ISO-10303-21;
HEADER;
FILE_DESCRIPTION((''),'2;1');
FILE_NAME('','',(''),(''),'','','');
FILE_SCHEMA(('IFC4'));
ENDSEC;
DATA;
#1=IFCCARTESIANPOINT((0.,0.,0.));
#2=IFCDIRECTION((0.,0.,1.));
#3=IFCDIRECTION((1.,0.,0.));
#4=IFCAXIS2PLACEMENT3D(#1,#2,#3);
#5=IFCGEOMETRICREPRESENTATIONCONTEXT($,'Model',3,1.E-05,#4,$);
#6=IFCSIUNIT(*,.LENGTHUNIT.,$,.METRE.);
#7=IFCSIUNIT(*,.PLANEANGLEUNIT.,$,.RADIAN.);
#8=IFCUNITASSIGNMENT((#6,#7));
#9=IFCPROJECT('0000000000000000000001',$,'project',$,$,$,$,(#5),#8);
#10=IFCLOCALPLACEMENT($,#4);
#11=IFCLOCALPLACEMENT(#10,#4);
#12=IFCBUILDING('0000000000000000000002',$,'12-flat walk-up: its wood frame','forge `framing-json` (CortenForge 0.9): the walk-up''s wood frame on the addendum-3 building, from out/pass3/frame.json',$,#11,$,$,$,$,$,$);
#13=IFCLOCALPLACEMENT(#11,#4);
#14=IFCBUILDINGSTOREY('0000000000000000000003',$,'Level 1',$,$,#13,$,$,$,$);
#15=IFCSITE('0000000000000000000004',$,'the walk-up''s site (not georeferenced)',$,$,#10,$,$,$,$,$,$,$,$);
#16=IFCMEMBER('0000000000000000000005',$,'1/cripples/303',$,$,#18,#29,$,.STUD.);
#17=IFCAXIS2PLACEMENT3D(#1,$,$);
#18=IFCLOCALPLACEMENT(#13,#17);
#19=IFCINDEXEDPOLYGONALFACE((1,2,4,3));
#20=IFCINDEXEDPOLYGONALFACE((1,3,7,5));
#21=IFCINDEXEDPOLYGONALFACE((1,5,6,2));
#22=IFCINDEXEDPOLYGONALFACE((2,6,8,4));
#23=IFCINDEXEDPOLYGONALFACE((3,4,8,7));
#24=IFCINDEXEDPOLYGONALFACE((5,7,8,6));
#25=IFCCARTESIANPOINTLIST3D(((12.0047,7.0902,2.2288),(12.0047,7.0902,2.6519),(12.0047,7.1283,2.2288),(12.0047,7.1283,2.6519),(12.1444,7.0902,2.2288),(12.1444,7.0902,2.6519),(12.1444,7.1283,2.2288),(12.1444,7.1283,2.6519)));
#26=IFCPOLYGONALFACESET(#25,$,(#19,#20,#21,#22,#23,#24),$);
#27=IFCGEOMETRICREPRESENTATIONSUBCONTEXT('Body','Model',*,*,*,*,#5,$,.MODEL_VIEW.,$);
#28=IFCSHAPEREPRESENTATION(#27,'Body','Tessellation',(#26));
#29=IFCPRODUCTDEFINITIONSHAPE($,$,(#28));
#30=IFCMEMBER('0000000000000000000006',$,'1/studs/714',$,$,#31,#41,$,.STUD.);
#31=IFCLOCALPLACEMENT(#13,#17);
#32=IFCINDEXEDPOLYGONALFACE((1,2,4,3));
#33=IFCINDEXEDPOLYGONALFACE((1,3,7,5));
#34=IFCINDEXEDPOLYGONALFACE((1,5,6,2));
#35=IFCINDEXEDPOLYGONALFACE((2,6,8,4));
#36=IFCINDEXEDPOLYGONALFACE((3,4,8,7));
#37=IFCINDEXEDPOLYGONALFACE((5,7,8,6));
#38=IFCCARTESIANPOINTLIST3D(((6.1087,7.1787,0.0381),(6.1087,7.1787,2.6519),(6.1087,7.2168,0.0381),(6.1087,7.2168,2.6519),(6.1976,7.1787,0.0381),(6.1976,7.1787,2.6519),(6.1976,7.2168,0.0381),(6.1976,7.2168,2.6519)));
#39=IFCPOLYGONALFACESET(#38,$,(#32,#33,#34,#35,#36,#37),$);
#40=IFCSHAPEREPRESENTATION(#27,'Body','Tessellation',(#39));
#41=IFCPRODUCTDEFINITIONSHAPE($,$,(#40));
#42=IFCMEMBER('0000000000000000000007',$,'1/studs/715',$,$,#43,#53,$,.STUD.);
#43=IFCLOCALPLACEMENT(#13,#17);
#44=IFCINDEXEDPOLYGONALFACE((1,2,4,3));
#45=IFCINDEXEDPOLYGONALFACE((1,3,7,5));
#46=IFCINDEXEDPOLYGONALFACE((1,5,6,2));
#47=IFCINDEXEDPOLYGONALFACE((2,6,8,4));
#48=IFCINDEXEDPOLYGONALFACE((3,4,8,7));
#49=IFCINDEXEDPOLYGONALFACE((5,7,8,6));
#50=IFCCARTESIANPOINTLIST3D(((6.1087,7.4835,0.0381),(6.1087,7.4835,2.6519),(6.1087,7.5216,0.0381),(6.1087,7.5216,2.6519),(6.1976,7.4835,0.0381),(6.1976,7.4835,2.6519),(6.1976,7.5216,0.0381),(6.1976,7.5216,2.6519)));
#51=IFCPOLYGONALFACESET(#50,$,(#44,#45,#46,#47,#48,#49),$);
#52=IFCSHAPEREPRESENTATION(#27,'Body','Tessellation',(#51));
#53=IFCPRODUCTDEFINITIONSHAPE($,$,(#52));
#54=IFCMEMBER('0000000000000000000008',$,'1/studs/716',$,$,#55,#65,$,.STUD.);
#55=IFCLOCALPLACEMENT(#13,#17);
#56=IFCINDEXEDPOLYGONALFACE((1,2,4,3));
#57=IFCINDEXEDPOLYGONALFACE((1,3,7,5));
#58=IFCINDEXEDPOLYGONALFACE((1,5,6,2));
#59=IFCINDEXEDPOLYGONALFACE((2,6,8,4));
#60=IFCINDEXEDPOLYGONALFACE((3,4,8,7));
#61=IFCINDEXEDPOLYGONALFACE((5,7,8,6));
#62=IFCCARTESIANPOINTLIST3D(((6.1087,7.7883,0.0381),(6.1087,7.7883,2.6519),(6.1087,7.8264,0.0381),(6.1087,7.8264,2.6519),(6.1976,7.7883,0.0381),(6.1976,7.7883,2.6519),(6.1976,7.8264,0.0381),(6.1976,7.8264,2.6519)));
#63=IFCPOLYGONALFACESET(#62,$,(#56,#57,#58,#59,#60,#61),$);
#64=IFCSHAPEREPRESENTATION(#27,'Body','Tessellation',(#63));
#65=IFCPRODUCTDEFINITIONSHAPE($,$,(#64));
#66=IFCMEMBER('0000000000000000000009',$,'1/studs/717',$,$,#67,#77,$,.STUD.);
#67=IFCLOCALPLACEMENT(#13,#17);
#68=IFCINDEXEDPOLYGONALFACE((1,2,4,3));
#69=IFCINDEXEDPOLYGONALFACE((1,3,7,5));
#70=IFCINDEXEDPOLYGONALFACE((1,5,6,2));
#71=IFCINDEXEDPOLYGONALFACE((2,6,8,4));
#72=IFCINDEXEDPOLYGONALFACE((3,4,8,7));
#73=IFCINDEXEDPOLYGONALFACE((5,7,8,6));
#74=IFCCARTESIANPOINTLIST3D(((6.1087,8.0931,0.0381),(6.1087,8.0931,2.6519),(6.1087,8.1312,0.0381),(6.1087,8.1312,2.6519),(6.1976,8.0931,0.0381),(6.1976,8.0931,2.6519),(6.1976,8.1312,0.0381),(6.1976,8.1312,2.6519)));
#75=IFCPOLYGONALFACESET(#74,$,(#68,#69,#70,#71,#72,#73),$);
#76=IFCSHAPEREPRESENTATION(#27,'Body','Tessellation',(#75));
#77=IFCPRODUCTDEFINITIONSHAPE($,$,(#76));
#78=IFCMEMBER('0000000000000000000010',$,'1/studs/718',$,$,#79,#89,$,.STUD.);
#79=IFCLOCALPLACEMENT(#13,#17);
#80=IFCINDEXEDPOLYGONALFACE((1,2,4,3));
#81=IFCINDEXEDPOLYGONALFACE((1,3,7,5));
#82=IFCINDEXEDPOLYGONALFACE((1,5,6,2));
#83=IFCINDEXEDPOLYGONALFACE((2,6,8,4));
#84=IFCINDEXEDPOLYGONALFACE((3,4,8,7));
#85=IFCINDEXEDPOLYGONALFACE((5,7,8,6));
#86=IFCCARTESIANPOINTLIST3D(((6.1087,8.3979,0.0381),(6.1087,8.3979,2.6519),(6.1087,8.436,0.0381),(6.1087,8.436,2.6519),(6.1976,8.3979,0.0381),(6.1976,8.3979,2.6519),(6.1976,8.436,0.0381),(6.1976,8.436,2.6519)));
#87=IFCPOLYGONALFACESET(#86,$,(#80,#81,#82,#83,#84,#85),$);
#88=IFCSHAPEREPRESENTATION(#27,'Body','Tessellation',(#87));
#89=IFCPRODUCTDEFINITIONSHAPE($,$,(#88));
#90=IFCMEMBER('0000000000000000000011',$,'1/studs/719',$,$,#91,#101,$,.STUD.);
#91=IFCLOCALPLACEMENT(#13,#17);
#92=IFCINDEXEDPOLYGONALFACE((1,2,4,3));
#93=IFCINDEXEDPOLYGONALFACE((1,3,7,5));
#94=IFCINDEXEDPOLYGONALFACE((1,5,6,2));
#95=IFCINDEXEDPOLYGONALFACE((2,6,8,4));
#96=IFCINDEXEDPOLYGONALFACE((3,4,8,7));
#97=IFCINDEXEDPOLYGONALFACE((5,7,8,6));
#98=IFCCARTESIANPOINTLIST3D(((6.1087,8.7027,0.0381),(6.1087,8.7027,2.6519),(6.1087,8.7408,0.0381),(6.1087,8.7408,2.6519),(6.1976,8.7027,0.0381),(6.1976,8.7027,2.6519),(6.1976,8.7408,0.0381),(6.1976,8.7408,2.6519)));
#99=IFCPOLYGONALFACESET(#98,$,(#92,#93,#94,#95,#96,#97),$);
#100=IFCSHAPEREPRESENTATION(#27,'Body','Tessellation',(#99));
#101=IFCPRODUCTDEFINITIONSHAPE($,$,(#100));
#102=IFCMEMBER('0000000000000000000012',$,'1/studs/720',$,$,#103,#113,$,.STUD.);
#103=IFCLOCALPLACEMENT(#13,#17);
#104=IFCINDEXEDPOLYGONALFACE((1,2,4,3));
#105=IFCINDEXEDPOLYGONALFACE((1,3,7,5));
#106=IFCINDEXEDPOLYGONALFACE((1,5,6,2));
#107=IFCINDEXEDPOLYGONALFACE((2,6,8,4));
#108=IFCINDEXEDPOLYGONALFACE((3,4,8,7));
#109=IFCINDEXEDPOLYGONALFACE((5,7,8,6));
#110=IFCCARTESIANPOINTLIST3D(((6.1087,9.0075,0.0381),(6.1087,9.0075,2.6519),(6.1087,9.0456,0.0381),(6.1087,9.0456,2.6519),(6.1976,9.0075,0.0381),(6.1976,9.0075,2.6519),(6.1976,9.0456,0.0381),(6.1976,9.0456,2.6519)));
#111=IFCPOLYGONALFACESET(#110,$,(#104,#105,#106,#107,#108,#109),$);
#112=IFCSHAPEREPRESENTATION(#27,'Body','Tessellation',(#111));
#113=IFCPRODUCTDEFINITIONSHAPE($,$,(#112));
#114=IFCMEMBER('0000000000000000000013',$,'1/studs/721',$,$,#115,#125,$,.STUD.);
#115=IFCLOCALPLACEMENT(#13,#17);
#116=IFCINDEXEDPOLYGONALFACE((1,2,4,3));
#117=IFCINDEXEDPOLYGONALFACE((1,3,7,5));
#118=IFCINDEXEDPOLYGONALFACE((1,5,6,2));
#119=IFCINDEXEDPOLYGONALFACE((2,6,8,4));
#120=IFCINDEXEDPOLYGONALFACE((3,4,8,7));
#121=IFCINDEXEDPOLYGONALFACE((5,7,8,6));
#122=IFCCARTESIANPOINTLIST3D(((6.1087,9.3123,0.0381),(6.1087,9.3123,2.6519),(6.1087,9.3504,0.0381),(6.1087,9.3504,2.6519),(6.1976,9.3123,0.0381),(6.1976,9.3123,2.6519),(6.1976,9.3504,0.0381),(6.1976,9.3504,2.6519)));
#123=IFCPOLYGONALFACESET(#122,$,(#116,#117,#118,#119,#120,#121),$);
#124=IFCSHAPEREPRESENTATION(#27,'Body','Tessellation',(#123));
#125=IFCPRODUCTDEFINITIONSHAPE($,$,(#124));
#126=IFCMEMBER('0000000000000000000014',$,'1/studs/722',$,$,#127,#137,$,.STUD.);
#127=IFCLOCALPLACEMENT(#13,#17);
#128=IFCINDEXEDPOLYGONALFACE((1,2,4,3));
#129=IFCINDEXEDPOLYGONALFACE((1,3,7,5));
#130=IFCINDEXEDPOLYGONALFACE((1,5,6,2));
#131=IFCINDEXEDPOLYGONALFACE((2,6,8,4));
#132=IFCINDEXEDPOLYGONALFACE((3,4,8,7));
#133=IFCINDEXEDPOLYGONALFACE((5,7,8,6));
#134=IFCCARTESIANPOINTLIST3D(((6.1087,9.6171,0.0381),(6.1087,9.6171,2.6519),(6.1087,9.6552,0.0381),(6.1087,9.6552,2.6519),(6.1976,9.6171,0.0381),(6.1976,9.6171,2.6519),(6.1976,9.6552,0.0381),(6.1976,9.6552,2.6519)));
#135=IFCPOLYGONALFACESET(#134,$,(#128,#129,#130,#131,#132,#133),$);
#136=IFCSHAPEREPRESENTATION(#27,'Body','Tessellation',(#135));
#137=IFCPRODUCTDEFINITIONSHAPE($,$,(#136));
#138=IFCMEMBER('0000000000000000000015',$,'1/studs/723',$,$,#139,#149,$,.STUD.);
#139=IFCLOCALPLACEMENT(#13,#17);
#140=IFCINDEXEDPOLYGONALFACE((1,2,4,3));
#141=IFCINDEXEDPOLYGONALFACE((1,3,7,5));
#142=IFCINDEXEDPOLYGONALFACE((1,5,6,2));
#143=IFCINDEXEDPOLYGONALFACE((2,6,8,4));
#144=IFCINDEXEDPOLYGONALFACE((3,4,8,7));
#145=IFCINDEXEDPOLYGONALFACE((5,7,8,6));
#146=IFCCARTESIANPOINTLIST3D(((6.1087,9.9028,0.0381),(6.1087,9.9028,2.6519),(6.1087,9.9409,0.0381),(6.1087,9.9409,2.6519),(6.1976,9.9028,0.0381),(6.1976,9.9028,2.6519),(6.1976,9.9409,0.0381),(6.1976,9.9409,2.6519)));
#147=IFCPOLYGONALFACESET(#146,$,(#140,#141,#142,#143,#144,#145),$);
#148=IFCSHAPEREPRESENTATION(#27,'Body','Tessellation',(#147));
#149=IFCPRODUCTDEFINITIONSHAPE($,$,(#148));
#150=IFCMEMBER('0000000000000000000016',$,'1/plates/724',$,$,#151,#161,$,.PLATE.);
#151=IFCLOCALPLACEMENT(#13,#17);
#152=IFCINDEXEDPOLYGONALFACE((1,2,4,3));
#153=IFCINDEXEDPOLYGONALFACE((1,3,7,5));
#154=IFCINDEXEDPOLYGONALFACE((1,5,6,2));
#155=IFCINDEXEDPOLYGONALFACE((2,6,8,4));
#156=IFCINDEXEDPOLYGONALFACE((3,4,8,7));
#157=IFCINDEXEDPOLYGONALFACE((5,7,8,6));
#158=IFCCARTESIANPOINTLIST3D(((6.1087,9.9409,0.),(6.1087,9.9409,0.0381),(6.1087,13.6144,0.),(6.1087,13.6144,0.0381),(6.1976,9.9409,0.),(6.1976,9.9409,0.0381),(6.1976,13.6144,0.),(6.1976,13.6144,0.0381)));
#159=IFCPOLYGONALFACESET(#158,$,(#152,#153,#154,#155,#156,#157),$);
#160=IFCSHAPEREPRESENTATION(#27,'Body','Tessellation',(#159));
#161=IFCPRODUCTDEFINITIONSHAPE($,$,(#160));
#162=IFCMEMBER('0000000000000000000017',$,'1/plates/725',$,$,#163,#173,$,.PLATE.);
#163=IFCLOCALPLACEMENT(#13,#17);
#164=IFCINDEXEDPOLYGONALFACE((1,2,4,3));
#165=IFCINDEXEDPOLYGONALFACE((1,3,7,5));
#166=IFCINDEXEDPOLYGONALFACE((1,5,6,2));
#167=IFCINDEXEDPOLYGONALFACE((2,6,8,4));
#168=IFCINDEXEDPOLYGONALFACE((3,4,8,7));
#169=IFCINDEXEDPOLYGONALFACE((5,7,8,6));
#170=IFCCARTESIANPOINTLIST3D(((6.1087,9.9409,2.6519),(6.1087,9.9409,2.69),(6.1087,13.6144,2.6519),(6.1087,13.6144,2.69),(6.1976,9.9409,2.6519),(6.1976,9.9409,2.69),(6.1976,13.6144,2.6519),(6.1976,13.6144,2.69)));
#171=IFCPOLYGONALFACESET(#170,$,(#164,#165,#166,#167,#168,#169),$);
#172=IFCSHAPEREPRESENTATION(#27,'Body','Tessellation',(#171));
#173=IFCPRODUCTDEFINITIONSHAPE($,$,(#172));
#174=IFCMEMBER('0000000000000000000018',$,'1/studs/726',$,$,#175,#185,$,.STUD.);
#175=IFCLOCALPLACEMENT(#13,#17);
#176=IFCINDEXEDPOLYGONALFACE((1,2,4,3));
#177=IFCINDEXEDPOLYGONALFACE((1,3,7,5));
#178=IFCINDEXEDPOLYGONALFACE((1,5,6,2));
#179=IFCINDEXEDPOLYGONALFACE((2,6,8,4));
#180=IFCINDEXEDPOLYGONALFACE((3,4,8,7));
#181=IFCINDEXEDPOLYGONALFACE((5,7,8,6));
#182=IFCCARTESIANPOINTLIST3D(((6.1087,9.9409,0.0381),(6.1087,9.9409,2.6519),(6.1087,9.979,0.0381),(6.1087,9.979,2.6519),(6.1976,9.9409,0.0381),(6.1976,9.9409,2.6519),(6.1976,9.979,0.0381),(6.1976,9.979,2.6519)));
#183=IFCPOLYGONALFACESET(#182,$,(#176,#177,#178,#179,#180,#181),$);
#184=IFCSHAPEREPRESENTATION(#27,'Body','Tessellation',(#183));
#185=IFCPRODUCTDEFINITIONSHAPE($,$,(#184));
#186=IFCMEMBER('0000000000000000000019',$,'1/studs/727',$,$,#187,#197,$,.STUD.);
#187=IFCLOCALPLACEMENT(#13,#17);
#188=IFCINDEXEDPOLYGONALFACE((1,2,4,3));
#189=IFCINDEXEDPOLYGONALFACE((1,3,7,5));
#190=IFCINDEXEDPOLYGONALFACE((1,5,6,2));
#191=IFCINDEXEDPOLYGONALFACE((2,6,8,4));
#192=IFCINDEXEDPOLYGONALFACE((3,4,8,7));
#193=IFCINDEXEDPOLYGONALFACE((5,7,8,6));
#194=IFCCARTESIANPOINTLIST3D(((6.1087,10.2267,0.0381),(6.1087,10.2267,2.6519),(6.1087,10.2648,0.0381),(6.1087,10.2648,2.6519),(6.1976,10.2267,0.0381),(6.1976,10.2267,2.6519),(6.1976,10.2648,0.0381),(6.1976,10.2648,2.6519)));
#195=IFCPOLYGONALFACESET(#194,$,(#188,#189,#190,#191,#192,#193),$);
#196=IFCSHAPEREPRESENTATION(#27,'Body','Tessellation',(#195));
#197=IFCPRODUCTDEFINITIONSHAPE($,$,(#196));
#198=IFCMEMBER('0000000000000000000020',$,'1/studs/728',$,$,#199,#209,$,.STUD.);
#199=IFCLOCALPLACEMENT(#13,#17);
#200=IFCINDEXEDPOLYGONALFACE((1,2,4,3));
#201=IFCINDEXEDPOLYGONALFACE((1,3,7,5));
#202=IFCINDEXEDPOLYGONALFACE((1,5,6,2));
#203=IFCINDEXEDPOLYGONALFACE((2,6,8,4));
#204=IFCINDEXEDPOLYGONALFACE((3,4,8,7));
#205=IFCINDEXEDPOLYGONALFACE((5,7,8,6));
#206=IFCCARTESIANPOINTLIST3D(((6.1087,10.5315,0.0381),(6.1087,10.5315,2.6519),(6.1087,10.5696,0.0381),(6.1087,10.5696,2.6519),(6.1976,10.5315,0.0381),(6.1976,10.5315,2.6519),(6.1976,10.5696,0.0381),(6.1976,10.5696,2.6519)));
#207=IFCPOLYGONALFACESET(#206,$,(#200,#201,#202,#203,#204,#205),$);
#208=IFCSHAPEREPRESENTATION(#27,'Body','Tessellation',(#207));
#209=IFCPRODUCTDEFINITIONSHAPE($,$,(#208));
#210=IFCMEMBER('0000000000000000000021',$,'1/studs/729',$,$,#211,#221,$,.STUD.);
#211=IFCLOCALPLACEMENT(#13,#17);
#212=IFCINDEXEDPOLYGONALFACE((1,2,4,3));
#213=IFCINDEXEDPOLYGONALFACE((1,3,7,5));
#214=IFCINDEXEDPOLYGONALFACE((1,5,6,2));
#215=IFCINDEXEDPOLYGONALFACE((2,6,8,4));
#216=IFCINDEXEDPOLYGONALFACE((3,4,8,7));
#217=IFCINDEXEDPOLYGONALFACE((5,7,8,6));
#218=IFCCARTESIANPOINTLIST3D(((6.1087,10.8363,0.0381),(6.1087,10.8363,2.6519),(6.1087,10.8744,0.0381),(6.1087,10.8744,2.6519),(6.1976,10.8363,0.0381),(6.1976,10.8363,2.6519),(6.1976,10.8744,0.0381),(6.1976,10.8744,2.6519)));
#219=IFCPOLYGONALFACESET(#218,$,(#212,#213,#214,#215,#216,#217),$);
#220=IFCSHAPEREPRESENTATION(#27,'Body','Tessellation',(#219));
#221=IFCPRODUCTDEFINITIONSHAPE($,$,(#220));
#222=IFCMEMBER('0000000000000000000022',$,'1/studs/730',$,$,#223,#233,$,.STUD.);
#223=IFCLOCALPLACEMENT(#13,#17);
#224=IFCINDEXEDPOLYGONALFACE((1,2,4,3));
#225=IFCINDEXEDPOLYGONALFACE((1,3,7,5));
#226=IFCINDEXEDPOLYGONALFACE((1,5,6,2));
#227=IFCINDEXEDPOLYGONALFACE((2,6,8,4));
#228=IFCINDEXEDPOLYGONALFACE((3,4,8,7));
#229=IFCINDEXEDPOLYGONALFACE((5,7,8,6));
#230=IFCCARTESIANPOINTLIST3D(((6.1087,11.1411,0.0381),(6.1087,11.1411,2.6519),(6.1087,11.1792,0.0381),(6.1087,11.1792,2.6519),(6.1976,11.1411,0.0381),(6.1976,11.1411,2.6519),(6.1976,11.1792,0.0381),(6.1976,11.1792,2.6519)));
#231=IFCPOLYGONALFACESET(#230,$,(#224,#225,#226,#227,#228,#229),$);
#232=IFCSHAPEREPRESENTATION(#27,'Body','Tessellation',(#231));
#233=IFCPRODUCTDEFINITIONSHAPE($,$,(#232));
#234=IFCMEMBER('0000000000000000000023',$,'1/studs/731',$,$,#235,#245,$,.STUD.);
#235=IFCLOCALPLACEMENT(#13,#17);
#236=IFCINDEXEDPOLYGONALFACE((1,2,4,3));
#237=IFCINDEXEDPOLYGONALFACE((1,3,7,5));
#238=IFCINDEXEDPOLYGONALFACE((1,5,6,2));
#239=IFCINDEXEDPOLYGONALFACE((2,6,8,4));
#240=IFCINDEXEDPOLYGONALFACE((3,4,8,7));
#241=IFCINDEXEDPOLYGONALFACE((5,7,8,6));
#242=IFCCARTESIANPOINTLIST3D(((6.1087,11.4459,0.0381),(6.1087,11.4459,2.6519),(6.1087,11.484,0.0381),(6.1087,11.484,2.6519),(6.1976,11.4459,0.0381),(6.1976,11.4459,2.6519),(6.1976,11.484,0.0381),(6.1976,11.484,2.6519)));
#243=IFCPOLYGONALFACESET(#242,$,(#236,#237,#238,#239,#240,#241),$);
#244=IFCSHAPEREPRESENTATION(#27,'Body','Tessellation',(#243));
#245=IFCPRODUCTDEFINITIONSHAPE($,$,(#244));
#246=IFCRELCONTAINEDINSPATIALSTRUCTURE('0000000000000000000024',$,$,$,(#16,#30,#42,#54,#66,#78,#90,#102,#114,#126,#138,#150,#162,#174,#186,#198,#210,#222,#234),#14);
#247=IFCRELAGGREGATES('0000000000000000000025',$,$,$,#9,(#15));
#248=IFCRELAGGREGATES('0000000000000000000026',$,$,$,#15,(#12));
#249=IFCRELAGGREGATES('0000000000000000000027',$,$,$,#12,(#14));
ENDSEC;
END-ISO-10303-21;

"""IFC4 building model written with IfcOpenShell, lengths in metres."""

from ifc_helpers import new_model, si_unit, frame, frame_2d, origin, origin_with_axes, place, context, subcontext, project, spatial, rectangle, extrude, element, save


model = new_model("IFC4")

# Units and contexts
model_context = context("Model", 3, precision=1e-05, world=origin_with_axes())
body_context = subcontext(model_context, "Body", "Model", "MODEL_VIEW")
ifc_project = project(units=[si_unit("LENGTHUNIT", "METRE"), si_unit("PLANEANGLEUNIT", "RADIAN")], contexts=[model_context])

# Site, building, storey
site_placement = place(None, origin_with_axes())
site = spatial("IfcSite", under=ifc_project, at=site_placement, Name="the walk-up's site (not georeferenced)")
building_placement = place(site_placement, origin_with_axes())
building = spatial("IfcBuilding", under=site, at=building_placement, Name="12-flat walk-up: its wood frame", Description="forge `framing-json` (CortenForge 0.9): the walk-up's wood frame on the addendum-3 building, from out/pass3/frame.json")
storey_placement = place(building_placement, origin_with_axes())
storey = spatial("IfcBuildingStorey", under=building, at=storey_placement, Name="Level 1")

# Members
member_1_placement = place(storey_placement, frame((12.0047, 7.0902, 2.2288), z_axis=(0.0, 0.0, 1.0), x_axis=(1.0, 0.0, 0.0)))
element("IfcMember", 1, at=member_1_placement, inside=storey, Name="1/cripples/303", PredefinedType="STUD", context=body_context, shape_type="SweptSolid", body=[
    extrude(rectangle(XDim=0.1397, YDim=0.0381, at=frame_2d((0.0698, 0.0191))), origin(), (0.0, 0.0, 1.0), 0.4231),
])
for number, where, z_axis, x_axis, name in (
    (2, (6.1087, 7.1787, 0.0381), (0.0, 0.0, 1.0), (1.0, 0.0, 0.0), "1/studs/714"),
    (3, (6.1087, 7.4835, 0.0381), (0.0, 0.0, 1.0), (1.0, 0.0, 0.0), "1/studs/715"),
    (4, (6.1087, 7.7883, 0.0381), (0.0, 0.0, 1.0), (1.0, 0.0, 0.0), "1/studs/716"),
    (5, (6.1087, 8.0931, 0.0381), (0.0, 0.0, 1.0), (1.0, 0.0, 0.0), "1/studs/717"),
):
    element("IfcMember", number, at=place(storey_placement, frame(where, z_axis=z_axis, x_axis=x_axis)), inside=storey, Name=name, PredefinedType="STUD", context=body_context, shape_type="SweptSolid", body=[
        extrude(rectangle(XDim=0.0889, YDim=0.0381, at=frame_2d((0.0445, 0.0191))), origin(), (0.0, 0.0, 1.0), 2.6138),
    ])
member_2_placement = place(storey_placement, frame((6.1087, 8.3979, 0.0381), z_axis=(0.0, 0.0, 1.0), x_axis=(1.0, 0.0, 0.0)))
element("IfcMember", 6, at=member_2_placement, inside=storey, Name="1/studs/718", PredefinedType="STUD", context=body_context, shape_type="SweptSolid", body=[
    extrude(rectangle(XDim=0.0889, YDim=0.0381, at=frame_2d((0.0445, 0.019))), origin(), (0.0, 0.0, 1.0), 2.6138),
])
for number, where, z_axis, x_axis, name in (
    (7, (6.1087, 8.7027, 0.0381), (0.0, 0.0, 1.0), (1.0, 0.0, 0.0), "1/studs/719"),
    (8, (6.1087, 9.0075, 0.0381), (0.0, 0.0, 1.0), (1.0, 0.0, 0.0), "1/studs/720"),
    (9, (6.1087, 9.3123, 0.0381), (0.0, 0.0, 1.0), (1.0, 0.0, 0.0), "1/studs/721"),
    (10, (6.1087, 9.6171, 0.0381), (0.0, 0.0, 1.0), (1.0, 0.0, 0.0), "1/studs/722"),
    (11, (6.1087, 9.9028, 0.0381), (0.0, 0.0, 1.0), (1.0, 0.0, 0.0), "1/studs/723"),
):
    element("IfcMember", number, at=place(storey_placement, frame(where, z_axis=z_axis, x_axis=x_axis)), inside=storey, Name=name, PredefinedType="STUD", context=body_context, shape_type="SweptSolid", body=[
        extrude(rectangle(XDim=0.0889, YDim=0.0381, at=frame_2d((0.0445, 0.0191))), origin(), (0.0, 0.0, 1.0), 2.6138),
    ])
member_3_placement = place(storey_placement, frame((6.1087, 9.9409, 0.0), z_axis=(0.0, 0.0, 1.0), x_axis=(1.0, 0.0, 0.0)))
element("IfcMember", 12, at=member_3_placement, inside=storey, Name="1/plates/724", PredefinedType="PLATE", context=body_context, shape_type="SweptSolid", body=[
    extrude(rectangle(XDim=0.0889, YDim=3.6735, at=frame_2d((0.0445, 1.8367))), origin(), (0.0, 0.0, 1.0), 0.0381),
])
member_4_placement = place(storey_placement, frame((6.1087, 9.9409, 2.6519), z_axis=(0.0, 0.0, 1.0), x_axis=(1.0, 0.0, 0.0)))
element("IfcMember", 13, at=member_4_placement, inside=storey, Name="1/plates/725", PredefinedType="PLATE", context=body_context, shape_type="SweptSolid", body=[
    extrude(rectangle(XDim=0.0889, YDim=3.6735, at=frame_2d((0.0445, 1.8367))), origin(), (0.0, 0.0, 1.0), 0.0381),
])
for number, where, z_axis, x_axis, name in (
    (14, (6.1087, 9.9409, 0.0381), (0.0, 0.0, 1.0), (1.0, 0.0, 0.0), "1/studs/726"),
    (15, (6.1087, 10.2267, 0.0381), (0.0, 0.0, 1.0), (1.0, 0.0, 0.0), "1/studs/727"),
    (16, (6.1087, 10.5315, 0.0381), (0.0, 0.0, 1.0), (1.0, 0.0, 0.0), "1/studs/728"),
    (17, (6.1087, 10.8363, 0.0381), (0.0, 0.0, 1.0), (1.0, 0.0, 0.0), "1/studs/729"),
    (18, (6.1087, 11.1411, 0.0381), (0.0, 0.0, 1.0), (1.0, 0.0, 0.0), "1/studs/730"),
    (19, (6.1087, 11.4459, 0.0381), (0.0, 0.0, 1.0), (1.0, 0.0, 0.0), "1/studs/731"),
):
    element("IfcMember", number, at=place(storey_placement, frame(where, z_axis=z_axis, x_axis=x_axis)), inside=storey, Name=name, PredefinedType="STUD", context=body_context, shape_type="SweptSolid", body=[
        extrude(rectangle(XDim=0.0889, YDim=0.0381, at=frame_2d((0.0445, 0.0191))), origin(), (0.0, 0.0, 1.0), 2.6138),
    ])

save(model, "model.ifc")
